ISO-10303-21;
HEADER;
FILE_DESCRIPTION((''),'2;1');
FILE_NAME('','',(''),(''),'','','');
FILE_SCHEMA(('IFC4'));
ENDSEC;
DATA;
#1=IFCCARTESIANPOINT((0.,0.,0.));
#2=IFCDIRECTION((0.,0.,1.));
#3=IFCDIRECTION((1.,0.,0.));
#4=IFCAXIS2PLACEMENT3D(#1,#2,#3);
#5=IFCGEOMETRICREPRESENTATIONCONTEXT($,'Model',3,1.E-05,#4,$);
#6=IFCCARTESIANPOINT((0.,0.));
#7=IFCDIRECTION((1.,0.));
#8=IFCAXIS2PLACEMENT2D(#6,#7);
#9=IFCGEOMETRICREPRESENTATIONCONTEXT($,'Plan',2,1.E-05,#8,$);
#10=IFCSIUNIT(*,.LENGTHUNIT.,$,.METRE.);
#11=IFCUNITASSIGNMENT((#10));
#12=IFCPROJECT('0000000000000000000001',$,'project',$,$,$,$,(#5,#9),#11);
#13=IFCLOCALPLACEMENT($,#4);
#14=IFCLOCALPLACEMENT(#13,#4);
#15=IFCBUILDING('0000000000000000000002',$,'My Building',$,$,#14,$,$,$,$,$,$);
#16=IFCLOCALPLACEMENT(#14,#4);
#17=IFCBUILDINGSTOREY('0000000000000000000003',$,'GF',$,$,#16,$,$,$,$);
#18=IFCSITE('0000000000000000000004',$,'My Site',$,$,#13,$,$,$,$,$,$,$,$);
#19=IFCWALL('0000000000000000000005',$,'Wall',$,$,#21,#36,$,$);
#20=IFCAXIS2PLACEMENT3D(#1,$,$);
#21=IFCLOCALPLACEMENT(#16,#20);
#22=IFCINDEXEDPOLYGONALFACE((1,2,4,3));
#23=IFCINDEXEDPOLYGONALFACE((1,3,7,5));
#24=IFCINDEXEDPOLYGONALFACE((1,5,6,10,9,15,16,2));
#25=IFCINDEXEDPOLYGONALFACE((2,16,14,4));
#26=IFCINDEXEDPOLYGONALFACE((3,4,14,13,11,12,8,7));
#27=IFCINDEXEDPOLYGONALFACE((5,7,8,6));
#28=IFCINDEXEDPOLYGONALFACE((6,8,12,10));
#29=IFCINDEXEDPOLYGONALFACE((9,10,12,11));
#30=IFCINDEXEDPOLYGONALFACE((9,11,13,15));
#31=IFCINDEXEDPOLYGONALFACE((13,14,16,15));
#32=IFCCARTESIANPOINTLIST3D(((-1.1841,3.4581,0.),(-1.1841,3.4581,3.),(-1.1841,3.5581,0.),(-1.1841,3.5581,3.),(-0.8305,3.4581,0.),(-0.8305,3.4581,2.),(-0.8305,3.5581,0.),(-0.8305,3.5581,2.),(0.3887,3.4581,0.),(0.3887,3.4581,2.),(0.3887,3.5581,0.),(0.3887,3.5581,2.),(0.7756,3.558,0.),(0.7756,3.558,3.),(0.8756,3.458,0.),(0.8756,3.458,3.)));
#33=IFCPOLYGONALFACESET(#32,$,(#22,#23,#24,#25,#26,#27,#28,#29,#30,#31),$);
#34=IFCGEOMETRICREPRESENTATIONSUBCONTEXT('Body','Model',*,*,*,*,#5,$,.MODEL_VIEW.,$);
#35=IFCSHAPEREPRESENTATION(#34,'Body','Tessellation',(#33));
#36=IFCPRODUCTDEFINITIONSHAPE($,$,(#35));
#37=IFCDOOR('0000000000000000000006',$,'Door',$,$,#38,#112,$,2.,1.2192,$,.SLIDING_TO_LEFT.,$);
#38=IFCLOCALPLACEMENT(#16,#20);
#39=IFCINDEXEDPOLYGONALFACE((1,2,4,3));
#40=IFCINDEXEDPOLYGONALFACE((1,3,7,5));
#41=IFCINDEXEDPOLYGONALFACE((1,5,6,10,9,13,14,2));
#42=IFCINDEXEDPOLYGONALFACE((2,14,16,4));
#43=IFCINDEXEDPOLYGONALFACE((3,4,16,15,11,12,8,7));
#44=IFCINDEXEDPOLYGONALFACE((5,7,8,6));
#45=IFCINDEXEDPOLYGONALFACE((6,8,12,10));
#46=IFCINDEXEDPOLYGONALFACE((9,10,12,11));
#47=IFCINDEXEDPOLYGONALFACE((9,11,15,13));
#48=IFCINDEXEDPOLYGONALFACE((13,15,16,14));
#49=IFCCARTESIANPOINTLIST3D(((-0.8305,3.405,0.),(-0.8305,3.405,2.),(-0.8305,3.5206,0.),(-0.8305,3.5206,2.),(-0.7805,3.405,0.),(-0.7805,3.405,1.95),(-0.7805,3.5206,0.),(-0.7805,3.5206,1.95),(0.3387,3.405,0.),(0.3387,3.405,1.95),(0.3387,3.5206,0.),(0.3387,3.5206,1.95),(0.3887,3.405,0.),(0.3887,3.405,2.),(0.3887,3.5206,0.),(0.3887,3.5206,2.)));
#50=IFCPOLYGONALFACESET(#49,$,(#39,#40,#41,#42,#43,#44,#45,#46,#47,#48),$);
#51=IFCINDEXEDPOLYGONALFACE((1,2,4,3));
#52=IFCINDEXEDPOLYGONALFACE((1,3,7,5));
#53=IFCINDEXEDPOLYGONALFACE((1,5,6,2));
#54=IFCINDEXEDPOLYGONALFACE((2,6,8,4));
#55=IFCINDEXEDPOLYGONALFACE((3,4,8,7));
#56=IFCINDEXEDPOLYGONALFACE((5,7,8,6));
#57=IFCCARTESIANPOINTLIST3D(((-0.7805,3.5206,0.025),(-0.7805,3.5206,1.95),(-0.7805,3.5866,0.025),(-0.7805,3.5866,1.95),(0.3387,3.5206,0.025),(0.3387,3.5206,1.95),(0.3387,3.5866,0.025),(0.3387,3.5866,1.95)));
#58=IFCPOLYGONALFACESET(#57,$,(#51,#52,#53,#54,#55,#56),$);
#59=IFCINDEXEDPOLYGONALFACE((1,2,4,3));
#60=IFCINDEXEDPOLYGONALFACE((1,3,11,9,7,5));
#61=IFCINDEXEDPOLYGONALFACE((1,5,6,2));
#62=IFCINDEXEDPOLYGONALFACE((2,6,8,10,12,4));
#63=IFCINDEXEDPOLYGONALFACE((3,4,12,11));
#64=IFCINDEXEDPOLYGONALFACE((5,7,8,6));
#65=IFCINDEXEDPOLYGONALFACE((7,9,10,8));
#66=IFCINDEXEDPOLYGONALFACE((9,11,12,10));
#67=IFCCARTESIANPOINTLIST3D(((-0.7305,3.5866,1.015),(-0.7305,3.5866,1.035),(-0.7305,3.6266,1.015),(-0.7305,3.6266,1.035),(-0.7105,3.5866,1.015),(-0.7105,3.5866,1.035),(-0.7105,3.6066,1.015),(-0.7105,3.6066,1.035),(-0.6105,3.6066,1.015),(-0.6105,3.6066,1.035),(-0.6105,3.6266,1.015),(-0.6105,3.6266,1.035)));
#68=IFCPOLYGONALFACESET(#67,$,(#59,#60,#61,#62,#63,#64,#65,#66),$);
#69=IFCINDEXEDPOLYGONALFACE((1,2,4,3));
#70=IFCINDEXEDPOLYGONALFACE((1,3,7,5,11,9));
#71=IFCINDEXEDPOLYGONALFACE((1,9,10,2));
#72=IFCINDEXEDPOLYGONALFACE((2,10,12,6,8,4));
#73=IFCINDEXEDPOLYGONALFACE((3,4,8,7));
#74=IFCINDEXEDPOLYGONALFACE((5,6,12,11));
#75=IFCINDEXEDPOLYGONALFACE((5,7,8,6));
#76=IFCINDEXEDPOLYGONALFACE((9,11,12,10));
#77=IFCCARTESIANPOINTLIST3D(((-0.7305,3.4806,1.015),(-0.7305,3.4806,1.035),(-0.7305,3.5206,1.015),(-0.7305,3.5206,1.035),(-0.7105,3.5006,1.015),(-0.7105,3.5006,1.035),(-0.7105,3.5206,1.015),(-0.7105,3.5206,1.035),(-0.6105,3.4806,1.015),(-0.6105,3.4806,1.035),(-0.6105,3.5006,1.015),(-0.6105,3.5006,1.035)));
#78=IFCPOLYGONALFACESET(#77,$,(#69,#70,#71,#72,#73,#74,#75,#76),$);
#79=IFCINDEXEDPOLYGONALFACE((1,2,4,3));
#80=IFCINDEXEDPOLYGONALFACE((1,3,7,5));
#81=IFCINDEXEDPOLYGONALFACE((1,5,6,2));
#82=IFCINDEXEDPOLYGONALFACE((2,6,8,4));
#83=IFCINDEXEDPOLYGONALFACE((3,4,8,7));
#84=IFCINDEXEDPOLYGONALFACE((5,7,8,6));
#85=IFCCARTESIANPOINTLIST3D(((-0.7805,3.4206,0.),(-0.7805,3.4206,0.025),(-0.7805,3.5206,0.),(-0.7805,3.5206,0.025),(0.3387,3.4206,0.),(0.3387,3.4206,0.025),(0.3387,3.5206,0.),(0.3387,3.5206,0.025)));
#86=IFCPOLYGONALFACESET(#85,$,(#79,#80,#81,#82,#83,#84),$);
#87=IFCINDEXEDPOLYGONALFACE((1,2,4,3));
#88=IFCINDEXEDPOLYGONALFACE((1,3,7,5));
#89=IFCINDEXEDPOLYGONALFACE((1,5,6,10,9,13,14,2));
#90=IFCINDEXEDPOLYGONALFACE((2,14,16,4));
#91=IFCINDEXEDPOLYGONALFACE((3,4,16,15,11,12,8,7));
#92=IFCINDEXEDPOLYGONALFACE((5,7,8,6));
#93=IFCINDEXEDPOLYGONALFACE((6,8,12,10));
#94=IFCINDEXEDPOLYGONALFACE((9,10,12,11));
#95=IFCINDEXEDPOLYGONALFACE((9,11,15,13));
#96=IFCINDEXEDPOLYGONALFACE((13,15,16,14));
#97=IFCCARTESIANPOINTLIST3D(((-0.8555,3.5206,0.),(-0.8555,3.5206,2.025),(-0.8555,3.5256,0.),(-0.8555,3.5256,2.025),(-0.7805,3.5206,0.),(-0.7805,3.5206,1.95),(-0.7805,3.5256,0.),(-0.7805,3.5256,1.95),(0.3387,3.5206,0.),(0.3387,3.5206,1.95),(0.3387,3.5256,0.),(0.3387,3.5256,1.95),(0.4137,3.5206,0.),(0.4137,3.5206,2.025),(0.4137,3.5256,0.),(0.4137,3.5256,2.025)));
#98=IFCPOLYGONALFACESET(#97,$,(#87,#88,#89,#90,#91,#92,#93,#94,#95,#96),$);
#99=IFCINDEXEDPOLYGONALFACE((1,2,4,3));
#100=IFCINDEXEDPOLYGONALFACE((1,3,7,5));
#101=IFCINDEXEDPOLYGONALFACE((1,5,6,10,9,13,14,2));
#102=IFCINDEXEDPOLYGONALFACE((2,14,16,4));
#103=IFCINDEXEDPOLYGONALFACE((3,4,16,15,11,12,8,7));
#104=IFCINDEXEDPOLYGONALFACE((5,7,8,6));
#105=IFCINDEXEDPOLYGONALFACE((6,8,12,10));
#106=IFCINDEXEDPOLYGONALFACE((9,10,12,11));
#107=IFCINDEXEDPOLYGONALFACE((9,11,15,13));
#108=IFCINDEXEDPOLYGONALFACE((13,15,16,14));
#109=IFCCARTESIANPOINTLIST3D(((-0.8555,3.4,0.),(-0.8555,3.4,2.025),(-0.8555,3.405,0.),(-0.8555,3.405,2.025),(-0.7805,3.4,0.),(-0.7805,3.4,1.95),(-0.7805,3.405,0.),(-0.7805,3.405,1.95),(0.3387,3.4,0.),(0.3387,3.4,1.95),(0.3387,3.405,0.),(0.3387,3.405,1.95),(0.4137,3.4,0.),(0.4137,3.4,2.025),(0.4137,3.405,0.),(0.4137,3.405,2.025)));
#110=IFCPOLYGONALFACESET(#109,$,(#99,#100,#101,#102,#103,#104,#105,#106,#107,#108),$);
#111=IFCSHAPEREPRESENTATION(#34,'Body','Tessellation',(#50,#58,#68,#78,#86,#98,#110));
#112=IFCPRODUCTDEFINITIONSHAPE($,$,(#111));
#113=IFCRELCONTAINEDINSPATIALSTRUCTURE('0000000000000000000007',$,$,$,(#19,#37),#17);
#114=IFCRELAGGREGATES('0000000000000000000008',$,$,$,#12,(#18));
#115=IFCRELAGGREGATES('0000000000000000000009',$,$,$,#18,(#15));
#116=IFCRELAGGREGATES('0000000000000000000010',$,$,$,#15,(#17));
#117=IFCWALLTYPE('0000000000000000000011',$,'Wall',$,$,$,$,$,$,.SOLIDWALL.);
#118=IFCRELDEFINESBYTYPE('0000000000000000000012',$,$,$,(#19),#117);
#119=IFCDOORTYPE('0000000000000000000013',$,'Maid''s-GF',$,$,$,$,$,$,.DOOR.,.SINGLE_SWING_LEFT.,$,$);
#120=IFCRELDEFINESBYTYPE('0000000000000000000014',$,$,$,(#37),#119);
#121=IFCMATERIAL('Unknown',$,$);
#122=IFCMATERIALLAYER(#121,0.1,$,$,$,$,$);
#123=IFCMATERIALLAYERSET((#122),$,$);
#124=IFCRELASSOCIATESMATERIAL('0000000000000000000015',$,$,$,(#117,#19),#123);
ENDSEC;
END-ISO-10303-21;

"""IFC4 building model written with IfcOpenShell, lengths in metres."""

from ifc_helpers import new_model, entity, si_unit, frame, origin_with_axes, origin_2d_with_axis, place, context, subcontext, project, spatial, line, indexed_curve, outline, extrude, shape, source, transform, mapped, material, layer, layer_set, layer_usage, type_object, type_shapes, element, fill, save


model = new_model("IFC4")

# Units and contexts
model_context = context("Model", 3, precision=1e-05, world=origin_with_axes())
plan_context = context("Plan", 2, precision=1e-05, world=origin_2d_with_axis())
body_context_1 = subcontext(model_context, "Body", "Model", "MODEL_VIEW")
body_context_2 = subcontext(plan_context, "Body", "Plan", "PLAN_VIEW")
ifc_project = project(units=[si_unit("LENGTHUNIT", "METRE")], contexts=[model_context, plan_context])

# Site, building, storey
site_placement = place(None, origin_with_axes())
site = spatial("IfcSite", under=ifc_project, at=site_placement, Name="My Site")
building_placement = place(site_placement, origin_with_axes())
building = spatial("IfcBuilding", under=site, at=building_placement, Name="My Building")
storey_placement = place(building_placement, origin_with_axes())
storey = spatial("IfcBuildingStorey", under=building, at=storey_placement, Name="GF")

# Shared definitions
ifc_material = material(Name="Unknown")

# Shared definitions
ifc_layer_1 = layer(ifc_material, 0.1)
ifc_layer_set_1 = layer_set([ifc_layer_1])
wall_type = type_object("IfcWallType", Name="Wall", PredefinedType="SOLIDWALL", material=ifc_layer_set_1)

# Wall, opening, door
ifc_layer_usage_1 = layer_usage(ifc_layer_set_1, "AXIS2", "POSITIVE", 0.0)
wall_1_placement = place(storey_placement, frame((0.7756, 3.558, 0.0), z_axis=(0.0, 0.0, 1.0), x_axis=(-1.0, 0.0, 0.0)))
wall_1 = element("IfcWall", 1, at=wall_1_placement, inside=storey, type_object=wall_type, material=ifc_layer_usage_1, Name="Wall", context=body_context_1, shape_type="SweptSolid", body=[
    extrude(outline(indexed_curve([(0.0, 0.0), (-0.1, 0.1), (1.9596, 0.1), (1.9596, 0.0)], segments=[line(1, 2, 3, 4, 1)])), origin_with_axes(), (0.0, 0.0, 1.0), 3.0),
])
shared_shape_1 = source(origin_with_axes(), body_context_1, "Body", "SweptSolid", [
    extrude(outline(indexed_curve([(0.0, 0.0), (1.2192, 0.0), (1.2192, 2.0), (0.0, 2.0)], segments=[line(1, 2, 3, 4, 1)])), frame((0.0, -0.6, 0.0), z_axis=(0.0, -1.0, 0.0), x_axis=(1.0, 0.0, 0.0)), (0.0, 0.0, -1.0), 1.2),
])
opening_1_placement = place(wall_1_placement, frame((0.3869, 0.0375, 0.0), z_axis=(0.0, 0.0, 1.0), x_axis=(1.0, -0.000003, 0.0)))
opening_1 = element("IfcOpeningElement", 2, at=opening_1_placement, cuts=wall_1, PredefinedType="OPENING", context=body_context_1, shape_type="MappedRepresentation", body=[
    mapped(shared_shape_1, transform((0.0, 0.0, 0.0), x_axis=(1.0, 0.0, 0.0), y_axis=(0.0, 1.0, 0.0), z_axis=(0.0, 0.0, 1.0), scale=1.0)),
])
door_type_1 = type_object("IfcDoorType", Name="Maid's-GF", OperationType="SINGLE_SWING_LEFT", PredefinedType="DOOR")
shared_shape_2 = source(origin_with_axes(), body_context_1, "Body", "SweptSolid", [
    extrude(outline(indexed_curve([(0.0, 0.0), (0.0, 2.0), (1.2192, 2.0), (1.2192, 0.0), (1.1692, 0.0), (1.1692, 1.95), (0.05, 1.95), (0.05, 0.0)], segments=[line(1, 2, 3, 4, 5, 6, 7, 8, 1)])), frame((0.0, 0.0, 0.0), z_axis=(0.0, -1.0, 0.0), x_axis=(1.0, 0.0, 0.0)), (0.0, 0.0, -1.0), 0.1156),
    extrude(outline(indexed_curve([(0.0, 0.0), (1.1192, 0.0), (1.1192, 0.0661), (0.0, 0.0661)], segments=[line(1, 2, 3, 4, 1)])), frame((0.05, -0.0661, 0.025), z_axis=(0.0, 0.0, 1.0), x_axis=(1.0, 0.0, 0.0)), (0.0, 0.0, 1.0), 1.925),
    extrude(outline(indexed_curve([(0.0, 0.0), (0.0, -0.04), (-0.12, -0.04), (-0.12, -0.02), (-0.02, -0.02), (-0.02, 0.0)], segments=[line(1, 2, 3, 4, 5, 6, 1)])), frame((1.1192, -0.0661, 1.015), z_axis=(0.0, 0.0, 1.0), x_axis=(1.0, 0.0, 0.0)), (0.0, 0.0, 1.0), 0.02),
    extrude(outline(indexed_curve([(0.0, 0.0), (0.0, 0.04), (-0.12, 0.04), (-0.12, 0.02), (-0.02, 0.02), (-0.02, 0.0)], segments=[line(1, 2, 3, 4, 5, 6, 1)])), frame((1.1192, 0.0, 1.015), z_axis=(0.0, 0.0, 1.0), x_axis=(1.0, 0.0, 0.0)), (0.0, 0.0, 1.0), 0.02),
    extrude(outline(indexed_curve([(0.0, 0.0), (1.1192, 0.0), (1.1192, 0.1), (0.0, 0.1)], segments=[line(1, 2, 3, 4, 1)])), frame((0.05, 0.0, 0.0), z_axis=(0.0, 0.0, 1.0), x_axis=(1.0, 0.0, 0.0)), (0.0, 0.0, 1.0), 0.025),
    extrude(outline(indexed_curve([(0.0, 0.0), (0.0, 2.025), (1.2692, 2.025), (1.2692, 0.0), (1.1942, 0.0), (1.1942, 1.95), (0.075, 1.95), (0.075, 0.0)], segments=[line(1, 2, 3, 4, 5, 6, 7, 8, 1)])), frame((-0.025, -0.005, 0.0), z_axis=(0.0, -1.0, 0.0), x_axis=(1.0, 0.0, 0.0)), (0.0, 0.0, -1.0), 0.005),
    extrude(outline(indexed_curve([(0.0, 0.0), (0.0, 2.025), (1.2692, 2.025), (1.2692, 0.0), (1.1942, 0.0), (1.1942, 1.95), (0.075, 1.95), (0.075, 0.0)], segments=[line(1, 2, 3, 4, 5, 6, 7, 8, 1)])), frame((-0.025, 0.1156, 0.0), z_axis=(0.0, -1.0, 0.0), x_axis=(1.0, 0.0, 0.0)), (0.0, 0.0, -1.0), 0.005),
])
shared_shape_3 = source(origin_with_axes(), body_context_2, "Body", "Curve2D", [
    entity("IfcIndexedPolyCurve", entity("IfcCartesianPointList2D", [[0.0, 0.0], [0.05, 0.0], [0.05, 0.1156], [0.0, 0.1156]]), [entity("IfcLineIndex", [1, 2, 3, 4, 1])]),
    entity("IfcIndexedPolyCurve", entity("IfcCartesianPointList2D", [[1.2192, 0.0], [1.1692, 0.0], [1.1692, 0.1156], [1.2192, 0.1156]]), [entity("IfcLineIndex", [1, 2, 3, 4, 1])]),
    entity("IfcIndexedPolyCurve", entity("IfcCartesianPointList2D", [[-0.5096, -0.0661], [0.6096, -0.0661], [0.6096, 0.0], [-0.5096, 0.0]]), [entity("IfcLineIndex", [1, 2, 3, 4, 1])]),
])
type_shapes(door_type_1, [shared_shape_2, shared_shape_3])
door_1_placement = place(opening_1_placement, frame((0.0, 0.0, 0.0), z_axis=(0.0, 0.0, 1.0), x_axis=(1.0, 0.0, 0.0)))
door_1 = element("IfcDoor", 3, at=door_1_placement, inside=storey, type_object=door_type_1, Name="Door", OperationType="SLIDING_TO_LEFT", OverallHeight=2.0, OverallWidth=1.2192, shapes=[
    shape(body_context_1, "Body", "MappedRepresentation", [mapped(shared_shape_2, transform((0.0, 0.0, 0.0), x_axis=(1.0, 0.0, 0.0), y_axis=(0.0, 1.0, 0.0), z_axis=(0.0, 0.0, 1.0), scale=1.0))]),
    shape(body_context_2, "Body", "MappedRepresentation", [mapped(shared_shape_3, transform((0.0, 0.0, 0.0), x_axis=(1.0, 0.0, 0.0), y_axis=(0.0, 1.0, 0.0), z_axis=(0.0, 0.0, 1.0), scale=1.0))]),
])
fill(opening_1, door_1)

save(model, "model.ifc")
